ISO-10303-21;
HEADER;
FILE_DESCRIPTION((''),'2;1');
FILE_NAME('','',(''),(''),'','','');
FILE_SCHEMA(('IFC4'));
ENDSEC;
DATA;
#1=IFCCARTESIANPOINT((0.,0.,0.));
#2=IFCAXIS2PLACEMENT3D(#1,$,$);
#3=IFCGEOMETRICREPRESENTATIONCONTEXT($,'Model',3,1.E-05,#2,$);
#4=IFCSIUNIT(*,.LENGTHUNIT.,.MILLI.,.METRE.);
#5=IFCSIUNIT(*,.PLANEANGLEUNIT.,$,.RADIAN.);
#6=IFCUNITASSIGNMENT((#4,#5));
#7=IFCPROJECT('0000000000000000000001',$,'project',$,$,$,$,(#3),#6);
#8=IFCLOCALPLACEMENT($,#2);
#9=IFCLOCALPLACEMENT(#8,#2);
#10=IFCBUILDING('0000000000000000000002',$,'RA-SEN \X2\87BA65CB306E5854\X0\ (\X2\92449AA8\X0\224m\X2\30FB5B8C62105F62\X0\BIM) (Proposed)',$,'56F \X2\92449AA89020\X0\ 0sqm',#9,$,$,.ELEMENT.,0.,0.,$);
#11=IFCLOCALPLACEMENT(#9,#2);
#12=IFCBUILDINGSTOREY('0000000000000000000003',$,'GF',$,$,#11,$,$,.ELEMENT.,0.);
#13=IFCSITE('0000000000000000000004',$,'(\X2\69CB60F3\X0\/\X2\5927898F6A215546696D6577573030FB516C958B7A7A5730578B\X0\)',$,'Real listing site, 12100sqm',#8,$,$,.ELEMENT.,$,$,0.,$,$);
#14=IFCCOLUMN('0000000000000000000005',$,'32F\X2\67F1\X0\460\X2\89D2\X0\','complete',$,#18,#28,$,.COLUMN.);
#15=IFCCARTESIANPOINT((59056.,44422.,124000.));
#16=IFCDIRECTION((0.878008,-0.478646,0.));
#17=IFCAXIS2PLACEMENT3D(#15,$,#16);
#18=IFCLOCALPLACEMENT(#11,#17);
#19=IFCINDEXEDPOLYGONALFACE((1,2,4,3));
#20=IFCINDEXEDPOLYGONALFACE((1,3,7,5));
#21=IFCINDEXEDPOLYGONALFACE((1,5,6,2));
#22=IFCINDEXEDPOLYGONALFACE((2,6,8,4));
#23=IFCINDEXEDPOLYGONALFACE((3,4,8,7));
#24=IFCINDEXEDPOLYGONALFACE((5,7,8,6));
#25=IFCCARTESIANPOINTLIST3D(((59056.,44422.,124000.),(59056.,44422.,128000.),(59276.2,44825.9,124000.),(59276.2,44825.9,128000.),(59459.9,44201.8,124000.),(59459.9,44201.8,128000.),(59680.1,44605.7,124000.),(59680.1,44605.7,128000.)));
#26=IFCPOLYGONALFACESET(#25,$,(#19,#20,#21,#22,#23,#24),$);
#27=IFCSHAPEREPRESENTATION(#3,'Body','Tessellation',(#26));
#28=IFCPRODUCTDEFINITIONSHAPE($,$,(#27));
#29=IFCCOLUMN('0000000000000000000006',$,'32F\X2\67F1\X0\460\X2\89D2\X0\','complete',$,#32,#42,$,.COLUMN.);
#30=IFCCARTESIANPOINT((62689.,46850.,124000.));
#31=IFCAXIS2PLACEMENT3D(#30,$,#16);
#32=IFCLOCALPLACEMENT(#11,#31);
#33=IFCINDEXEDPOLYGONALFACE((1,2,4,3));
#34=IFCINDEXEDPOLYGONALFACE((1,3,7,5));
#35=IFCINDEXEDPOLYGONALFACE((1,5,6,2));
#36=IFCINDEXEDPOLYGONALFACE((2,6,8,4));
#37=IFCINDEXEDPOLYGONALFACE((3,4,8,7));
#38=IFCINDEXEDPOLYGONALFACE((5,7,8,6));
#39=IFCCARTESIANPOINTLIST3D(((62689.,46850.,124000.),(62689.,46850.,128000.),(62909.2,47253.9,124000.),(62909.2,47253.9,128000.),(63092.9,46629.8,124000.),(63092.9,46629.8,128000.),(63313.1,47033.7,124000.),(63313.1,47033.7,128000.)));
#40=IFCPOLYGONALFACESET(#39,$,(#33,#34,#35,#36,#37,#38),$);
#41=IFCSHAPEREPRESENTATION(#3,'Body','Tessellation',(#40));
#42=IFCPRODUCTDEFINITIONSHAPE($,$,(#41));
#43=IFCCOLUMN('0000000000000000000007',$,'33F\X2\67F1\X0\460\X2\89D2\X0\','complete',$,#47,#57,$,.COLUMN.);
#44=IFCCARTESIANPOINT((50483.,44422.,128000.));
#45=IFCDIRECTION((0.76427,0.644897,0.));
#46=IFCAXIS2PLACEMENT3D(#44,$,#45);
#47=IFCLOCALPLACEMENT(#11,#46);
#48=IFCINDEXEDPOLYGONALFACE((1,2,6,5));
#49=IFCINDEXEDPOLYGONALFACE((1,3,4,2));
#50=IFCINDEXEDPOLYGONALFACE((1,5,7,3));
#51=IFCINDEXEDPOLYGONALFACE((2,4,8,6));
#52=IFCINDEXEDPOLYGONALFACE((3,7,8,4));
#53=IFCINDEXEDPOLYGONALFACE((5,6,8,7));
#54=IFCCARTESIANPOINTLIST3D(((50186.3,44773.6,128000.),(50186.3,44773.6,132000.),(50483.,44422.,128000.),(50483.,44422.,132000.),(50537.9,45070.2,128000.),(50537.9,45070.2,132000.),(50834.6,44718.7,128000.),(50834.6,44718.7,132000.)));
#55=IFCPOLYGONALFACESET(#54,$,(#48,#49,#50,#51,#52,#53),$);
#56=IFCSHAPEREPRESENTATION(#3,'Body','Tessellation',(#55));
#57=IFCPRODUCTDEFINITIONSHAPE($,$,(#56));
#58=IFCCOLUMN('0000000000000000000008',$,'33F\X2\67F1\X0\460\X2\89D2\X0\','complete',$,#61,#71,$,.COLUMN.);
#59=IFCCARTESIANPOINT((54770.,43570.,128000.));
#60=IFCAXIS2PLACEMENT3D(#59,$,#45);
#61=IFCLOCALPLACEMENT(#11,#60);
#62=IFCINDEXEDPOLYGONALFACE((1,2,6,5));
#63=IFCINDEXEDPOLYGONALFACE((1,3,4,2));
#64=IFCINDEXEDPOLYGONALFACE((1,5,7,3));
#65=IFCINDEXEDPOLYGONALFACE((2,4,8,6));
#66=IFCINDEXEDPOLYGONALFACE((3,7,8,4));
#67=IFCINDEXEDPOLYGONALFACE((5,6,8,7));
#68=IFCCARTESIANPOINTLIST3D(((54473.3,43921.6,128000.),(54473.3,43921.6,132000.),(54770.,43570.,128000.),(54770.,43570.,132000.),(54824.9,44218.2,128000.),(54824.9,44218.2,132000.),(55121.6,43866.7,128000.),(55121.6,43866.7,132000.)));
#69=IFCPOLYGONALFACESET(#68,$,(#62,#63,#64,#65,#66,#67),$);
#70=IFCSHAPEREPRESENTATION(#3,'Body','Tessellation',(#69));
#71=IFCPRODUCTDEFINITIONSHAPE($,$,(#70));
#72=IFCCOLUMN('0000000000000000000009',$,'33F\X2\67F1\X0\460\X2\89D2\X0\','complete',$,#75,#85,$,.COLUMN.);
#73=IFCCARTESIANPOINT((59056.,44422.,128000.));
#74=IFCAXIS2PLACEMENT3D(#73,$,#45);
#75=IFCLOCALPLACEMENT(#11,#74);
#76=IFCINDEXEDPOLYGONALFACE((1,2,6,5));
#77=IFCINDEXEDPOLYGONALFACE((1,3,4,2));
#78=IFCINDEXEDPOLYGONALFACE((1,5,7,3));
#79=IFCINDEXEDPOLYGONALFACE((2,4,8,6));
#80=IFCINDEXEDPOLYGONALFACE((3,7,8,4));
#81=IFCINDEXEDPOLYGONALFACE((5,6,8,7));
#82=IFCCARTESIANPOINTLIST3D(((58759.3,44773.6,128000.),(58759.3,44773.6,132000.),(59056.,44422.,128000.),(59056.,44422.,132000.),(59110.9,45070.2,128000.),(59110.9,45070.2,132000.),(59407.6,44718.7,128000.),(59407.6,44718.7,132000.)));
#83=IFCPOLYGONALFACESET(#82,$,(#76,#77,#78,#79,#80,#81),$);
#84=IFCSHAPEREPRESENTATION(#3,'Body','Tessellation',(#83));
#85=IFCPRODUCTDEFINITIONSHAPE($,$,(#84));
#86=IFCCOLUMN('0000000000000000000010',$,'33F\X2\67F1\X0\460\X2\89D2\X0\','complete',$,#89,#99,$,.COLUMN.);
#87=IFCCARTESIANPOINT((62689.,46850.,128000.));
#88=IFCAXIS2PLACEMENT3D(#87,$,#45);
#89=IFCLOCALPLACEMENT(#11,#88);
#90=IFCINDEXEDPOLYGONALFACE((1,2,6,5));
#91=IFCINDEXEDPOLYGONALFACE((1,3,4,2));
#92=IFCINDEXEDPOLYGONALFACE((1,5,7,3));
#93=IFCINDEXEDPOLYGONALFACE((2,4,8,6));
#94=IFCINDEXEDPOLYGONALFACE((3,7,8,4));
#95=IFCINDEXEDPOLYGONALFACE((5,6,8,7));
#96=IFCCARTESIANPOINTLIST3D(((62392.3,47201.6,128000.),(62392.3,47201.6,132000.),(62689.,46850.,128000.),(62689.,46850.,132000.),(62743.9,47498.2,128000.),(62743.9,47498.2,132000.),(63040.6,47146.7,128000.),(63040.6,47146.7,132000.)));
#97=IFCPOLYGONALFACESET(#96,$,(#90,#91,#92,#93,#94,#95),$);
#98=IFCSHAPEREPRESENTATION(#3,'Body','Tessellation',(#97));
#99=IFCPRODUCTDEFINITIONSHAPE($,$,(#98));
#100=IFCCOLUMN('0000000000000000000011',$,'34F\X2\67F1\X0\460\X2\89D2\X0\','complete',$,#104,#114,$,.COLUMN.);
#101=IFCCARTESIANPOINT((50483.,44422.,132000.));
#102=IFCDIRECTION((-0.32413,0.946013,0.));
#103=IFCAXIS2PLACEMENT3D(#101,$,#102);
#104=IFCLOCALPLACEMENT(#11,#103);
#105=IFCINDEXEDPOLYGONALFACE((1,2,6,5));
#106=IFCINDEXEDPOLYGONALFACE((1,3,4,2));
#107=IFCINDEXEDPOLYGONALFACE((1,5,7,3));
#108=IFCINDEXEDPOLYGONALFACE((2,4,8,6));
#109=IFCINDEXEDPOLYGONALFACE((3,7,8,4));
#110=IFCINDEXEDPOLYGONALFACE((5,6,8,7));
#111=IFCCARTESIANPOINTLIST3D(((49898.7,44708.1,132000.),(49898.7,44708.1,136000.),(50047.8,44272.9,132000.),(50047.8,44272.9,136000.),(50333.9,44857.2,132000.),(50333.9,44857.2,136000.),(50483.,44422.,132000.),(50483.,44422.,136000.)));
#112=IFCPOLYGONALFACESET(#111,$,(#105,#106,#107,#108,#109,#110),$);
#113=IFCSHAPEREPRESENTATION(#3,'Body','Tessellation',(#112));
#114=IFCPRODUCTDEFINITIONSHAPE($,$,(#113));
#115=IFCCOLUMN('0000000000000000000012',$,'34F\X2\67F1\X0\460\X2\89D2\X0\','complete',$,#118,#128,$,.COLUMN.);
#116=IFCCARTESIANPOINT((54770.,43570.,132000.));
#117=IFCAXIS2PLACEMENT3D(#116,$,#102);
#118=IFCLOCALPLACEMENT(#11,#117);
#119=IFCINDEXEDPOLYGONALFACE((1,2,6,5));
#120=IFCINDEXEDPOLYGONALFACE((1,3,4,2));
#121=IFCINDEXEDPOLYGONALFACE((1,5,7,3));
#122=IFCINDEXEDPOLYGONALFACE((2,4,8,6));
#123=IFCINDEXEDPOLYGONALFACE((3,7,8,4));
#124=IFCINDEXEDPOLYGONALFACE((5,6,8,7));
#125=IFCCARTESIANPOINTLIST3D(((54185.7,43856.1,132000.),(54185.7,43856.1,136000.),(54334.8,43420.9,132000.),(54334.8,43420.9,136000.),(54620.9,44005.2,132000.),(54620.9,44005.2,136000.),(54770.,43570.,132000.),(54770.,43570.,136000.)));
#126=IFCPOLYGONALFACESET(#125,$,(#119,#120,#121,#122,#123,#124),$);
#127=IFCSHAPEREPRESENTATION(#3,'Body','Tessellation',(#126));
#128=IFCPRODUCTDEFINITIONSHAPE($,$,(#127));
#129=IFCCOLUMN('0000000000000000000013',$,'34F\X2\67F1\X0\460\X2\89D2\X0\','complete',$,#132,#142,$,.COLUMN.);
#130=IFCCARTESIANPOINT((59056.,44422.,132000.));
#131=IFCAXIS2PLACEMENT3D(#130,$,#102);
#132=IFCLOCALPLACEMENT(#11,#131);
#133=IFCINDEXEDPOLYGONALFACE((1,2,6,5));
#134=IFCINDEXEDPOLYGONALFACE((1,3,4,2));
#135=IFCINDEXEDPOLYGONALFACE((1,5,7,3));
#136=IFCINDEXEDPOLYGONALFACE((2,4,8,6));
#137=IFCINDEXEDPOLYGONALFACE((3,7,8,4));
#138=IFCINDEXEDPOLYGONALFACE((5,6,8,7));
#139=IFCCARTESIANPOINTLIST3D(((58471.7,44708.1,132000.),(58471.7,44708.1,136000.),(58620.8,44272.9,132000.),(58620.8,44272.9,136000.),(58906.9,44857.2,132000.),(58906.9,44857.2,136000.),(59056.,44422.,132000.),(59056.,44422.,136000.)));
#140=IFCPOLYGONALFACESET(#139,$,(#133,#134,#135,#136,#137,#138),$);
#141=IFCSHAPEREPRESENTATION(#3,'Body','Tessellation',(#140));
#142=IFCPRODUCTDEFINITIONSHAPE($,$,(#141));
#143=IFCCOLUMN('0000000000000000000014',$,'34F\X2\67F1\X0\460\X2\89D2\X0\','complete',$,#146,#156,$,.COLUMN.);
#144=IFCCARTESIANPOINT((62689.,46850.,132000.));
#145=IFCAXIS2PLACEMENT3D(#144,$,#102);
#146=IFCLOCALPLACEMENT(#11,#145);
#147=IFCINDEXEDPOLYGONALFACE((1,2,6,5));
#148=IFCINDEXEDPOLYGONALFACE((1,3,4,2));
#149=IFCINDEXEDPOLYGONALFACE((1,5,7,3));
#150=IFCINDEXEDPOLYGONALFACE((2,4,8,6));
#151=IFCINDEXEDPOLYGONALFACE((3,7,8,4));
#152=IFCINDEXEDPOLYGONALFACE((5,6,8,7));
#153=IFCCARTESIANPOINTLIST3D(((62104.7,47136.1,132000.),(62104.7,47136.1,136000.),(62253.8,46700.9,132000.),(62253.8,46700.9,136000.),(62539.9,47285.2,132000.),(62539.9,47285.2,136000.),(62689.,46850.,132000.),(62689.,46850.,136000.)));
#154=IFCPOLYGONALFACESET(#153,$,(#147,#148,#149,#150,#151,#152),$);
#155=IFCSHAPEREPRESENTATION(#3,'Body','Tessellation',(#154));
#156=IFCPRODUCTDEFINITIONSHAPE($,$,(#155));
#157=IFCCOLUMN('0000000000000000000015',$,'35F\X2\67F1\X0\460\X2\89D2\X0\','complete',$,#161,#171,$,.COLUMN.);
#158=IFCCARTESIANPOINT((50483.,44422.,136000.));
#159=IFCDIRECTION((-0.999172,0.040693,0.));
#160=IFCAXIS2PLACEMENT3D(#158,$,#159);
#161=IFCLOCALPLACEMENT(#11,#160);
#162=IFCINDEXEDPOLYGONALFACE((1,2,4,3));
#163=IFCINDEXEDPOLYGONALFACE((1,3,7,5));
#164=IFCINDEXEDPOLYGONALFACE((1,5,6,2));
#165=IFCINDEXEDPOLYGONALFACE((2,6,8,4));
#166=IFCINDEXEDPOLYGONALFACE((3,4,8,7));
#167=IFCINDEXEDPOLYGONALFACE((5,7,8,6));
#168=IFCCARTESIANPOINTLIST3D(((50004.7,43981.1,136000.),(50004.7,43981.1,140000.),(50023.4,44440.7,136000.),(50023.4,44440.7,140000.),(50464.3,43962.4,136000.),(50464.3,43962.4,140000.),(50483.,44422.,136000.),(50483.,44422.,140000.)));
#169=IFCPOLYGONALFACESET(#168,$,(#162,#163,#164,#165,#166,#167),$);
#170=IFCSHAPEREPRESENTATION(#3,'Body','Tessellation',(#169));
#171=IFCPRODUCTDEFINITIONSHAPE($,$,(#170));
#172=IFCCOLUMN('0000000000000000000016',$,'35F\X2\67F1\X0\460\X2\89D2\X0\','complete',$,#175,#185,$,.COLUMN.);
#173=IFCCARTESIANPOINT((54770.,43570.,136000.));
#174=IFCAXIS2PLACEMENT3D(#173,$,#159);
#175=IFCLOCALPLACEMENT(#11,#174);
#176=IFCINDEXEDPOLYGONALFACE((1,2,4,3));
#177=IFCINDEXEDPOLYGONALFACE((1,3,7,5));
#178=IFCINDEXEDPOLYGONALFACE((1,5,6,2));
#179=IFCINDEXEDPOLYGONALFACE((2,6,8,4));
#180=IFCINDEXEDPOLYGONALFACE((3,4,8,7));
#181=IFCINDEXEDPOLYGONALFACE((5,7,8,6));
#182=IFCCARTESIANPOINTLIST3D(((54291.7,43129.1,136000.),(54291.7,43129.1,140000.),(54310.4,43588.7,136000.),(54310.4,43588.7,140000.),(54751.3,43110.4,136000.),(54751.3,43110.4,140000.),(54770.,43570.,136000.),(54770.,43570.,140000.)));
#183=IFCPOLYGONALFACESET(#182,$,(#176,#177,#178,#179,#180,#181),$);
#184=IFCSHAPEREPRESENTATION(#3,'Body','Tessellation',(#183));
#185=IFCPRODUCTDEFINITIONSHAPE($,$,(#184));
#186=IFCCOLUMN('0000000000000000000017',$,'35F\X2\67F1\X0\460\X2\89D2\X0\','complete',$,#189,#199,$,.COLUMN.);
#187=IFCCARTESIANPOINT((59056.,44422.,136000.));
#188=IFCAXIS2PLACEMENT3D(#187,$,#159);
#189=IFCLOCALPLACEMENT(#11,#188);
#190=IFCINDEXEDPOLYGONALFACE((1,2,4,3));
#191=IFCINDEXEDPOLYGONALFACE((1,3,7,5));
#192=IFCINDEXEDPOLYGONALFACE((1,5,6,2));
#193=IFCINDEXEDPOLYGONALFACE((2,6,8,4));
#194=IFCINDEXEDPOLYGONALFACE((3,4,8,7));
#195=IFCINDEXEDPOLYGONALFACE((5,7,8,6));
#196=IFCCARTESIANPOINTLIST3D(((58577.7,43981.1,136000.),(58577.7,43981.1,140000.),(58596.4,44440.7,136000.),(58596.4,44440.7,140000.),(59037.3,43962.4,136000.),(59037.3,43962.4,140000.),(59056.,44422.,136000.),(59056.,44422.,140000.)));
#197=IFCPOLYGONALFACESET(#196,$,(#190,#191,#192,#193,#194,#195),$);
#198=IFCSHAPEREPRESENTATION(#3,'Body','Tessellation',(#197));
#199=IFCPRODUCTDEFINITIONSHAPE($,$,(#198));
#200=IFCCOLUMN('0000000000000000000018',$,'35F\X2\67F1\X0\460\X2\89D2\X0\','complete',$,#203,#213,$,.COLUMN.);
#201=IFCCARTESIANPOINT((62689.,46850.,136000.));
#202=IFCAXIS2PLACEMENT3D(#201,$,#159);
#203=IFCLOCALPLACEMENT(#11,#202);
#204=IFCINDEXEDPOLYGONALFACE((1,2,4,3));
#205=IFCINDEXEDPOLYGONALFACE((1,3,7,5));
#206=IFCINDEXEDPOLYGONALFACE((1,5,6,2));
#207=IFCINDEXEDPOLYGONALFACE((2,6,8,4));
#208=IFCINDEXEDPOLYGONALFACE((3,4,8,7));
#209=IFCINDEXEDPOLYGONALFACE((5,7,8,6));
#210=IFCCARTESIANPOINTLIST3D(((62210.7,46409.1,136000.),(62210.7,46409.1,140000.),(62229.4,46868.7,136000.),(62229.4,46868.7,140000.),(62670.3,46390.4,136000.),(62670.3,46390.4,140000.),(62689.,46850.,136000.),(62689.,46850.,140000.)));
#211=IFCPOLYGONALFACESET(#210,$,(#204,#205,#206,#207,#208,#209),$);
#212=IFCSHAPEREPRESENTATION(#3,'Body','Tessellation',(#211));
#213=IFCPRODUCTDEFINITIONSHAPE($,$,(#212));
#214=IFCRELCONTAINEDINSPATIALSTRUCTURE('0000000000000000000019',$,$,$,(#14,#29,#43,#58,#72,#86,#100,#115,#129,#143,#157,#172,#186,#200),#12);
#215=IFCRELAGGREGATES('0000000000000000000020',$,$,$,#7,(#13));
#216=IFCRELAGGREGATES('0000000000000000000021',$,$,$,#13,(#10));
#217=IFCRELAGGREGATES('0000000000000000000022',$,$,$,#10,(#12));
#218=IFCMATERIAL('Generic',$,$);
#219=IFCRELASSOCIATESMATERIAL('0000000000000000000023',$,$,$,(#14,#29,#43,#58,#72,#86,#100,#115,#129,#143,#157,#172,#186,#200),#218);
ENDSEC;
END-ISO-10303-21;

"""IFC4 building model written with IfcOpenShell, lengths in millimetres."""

from ifc_helpers import new_model, si_unit, frame, frame_2d, origin, place, context, project, spatial, rectangle, extrude, material, element, save


model = new_model("IFC4")

# Units and contexts
model_context = context("Model", 3, precision=1e-05, world=origin())
ifc_project = project(units=[si_unit("LENGTHUNIT", "METRE", prefix="MILLI"), si_unit("PLANEANGLEUNIT", "RADIAN")], contexts=[model_context])

# Site, building, storey
site_placement = place(None, origin())
site = spatial("IfcSite", under=ifc_project, at=site_placement, Name="(構想/大規模商業敷地・公開空地型)", ObjectType="Real listing site, 12100sqm", CompositionType="ELEMENT", RefElevation=0.0)
building_placement = place(site_placement, origin())
building = spatial("IfcBuilding", under=site, at=building_placement, Name="RA-SEN 螺旋の塔 (鉄骨224m・完成形BIM) (Proposed)", ObjectType="56F 鉄骨造 0sqm", CompositionType="ELEMENT", ElevationOfRefHeight=0.0, ElevationOfTerrain=0.0)
storey_placement = place(building_placement, origin())
storey = spatial("IfcBuildingStorey", under=building, at=storey_placement, Name="GF", CompositionType="ELEMENT", Elevation=0.0)

# Columns
ifc_material = material(Name="Generic")
column_1_placement = place(storey_placement, frame((59056.0, 44422.0, 124000.0), x_axis=(0.878008, -0.478646, 0.0)))
element("IfcColumn", 1, at=column_1_placement, inside=storey, material=ifc_material, Name="32F柱460角", Description="complete", PredefinedType="COLUMN", context=model_context, shape_type="SweptSolid", body=[
    extrude(rectangle(XDim=460.0, YDim=460.0, at=frame_2d((230.0, 230.0))), frame((59056.0, 44422.0, 124000.0), x_axis=(0.878008, -0.478646, 0.0)), (0.0, 0.0, 1.0), 4000.0),
])
column_2_placement = place(storey_placement, frame((62689.0, 46850.0, 124000.0), x_axis=(0.878008, -0.478646, 0.0)))
element("IfcColumn", 2, at=column_2_placement, inside=storey, material=ifc_material, Name="32F柱460角", Description="complete", PredefinedType="COLUMN", context=model_context, shape_type="SweptSolid", body=[
    extrude(rectangle(XDim=460.0, YDim=460.0, at=frame_2d((230.0, 230.0))), frame((62689.0, 46850.0, 124000.0), x_axis=(0.878008, -0.478646, 0.0)), (0.0, 0.0, 1.0), 4000.0),
])
column_3_placement = place(storey_placement, frame((50483.0, 44422.0, 128000.0), x_axis=(0.76427, 0.644897, 0.0)))
element("IfcColumn", 3, at=column_3_placement, inside=storey, material=ifc_material, Name="33F柱460角", Description="complete", PredefinedType="COLUMN", context=model_context, shape_type="SweptSolid", body=[
    extrude(rectangle(XDim=460.0, YDim=460.0, at=frame_2d((230.0, 230.0))), frame((50483.0, 44422.0, 128000.0), x_axis=(0.76427, 0.644897, 0.0)), (0.0, 0.0, 1.0), 4000.0),
])
column_4_placement = place(storey_placement, frame((54770.0, 43570.0, 128000.0), x_axis=(0.76427, 0.644897, 0.0)))
element("IfcColumn", 4, at=column_4_placement, inside=storey, material=ifc_material, Name="33F柱460角", Description="complete", PredefinedType="COLUMN", context=model_context, shape_type="SweptSolid", body=[
    extrude(rectangle(XDim=460.0, YDim=460.0, at=frame_2d((230.0, 230.0))), frame((54770.0, 43570.0, 128000.0), x_axis=(0.76427, 0.644897, 0.0)), (0.0, 0.0, 1.0), 4000.0),
])
column_5_placement = place(storey_placement, frame((59056.0, 44422.0, 128000.0), x_axis=(0.76427, 0.644897, 0.0)))
element("IfcColumn", 5, at=column_5_placement, inside=storey, material=ifc_material, Name="33F柱460角", Description="complete", PredefinedType="COLUMN", context=model_context, shape_type="SweptSolid", body=[
    extrude(rectangle(XDim=460.0, YDim=460.0, at=frame_2d((230.0, 230.0))), frame((59056.0, 44422.0, 128000.0), x_axis=(0.76427, 0.644897, 0.0)), (0.0, 0.0, 1.0), 4000.0),
])
column_6_placement = place(storey_placement, frame((62689.0, 46850.0, 128000.0), x_axis=(0.76427, 0.644897, 0.0)))
element("IfcColumn", 6, at=column_6_placement, inside=storey, material=ifc_material, Name="33F柱460角", Description="complete", PredefinedType="COLUMN", context=model_context, shape_type="SweptSolid", body=[
    extrude(rectangle(XDim=460.0, YDim=460.0, at=frame_2d((230.0, 230.0))), frame((62689.0, 46850.0, 128000.0), x_axis=(0.76427, 0.644897, 0.0)), (0.0, 0.0, 1.0), 4000.0),
])
column_7_placement = place(storey_placement, frame((50483.0, 44422.0, 132000.0), x_axis=(-0.32413, 0.946013, 0.0)))
element("IfcColumn", 7, at=column_7_placement, inside=storey, material=ifc_material, Name="34F柱460角", Description="complete", PredefinedType="COLUMN", context=model_context, shape_type="SweptSolid", body=[
    extrude(rectangle(XDim=460.0, YDim=460.0, at=frame_2d((230.0, 230.0))), frame((50483.0, 44422.0, 132000.0), x_axis=(-0.32413, 0.946013, 0.0)), (0.0, 0.0, 1.0), 4000.0),
])
column_8_placement = place(storey_placement, frame((54770.0, 43570.0, 132000.0), x_axis=(-0.32413, 0.946013, 0.0)))
element("IfcColumn", 8, at=column_8_placement, inside=storey, material=ifc_material, Name="34F柱460角", Description="complete", PredefinedType="COLUMN", context=model_context, shape_type="SweptSolid", body=[
    extrude(rectangle(XDim=460.0, YDim=460.0, at=frame_2d((230.0, 230.0))), frame((54770.0, 43570.0, 132000.0), x_axis=(-0.32413, 0.946013, 0.0)), (0.0, 0.0, 1.0), 4000.0),
])
column_9_placement = place(storey_placement, frame((59056.0, 44422.0, 132000.0), x_axis=(-0.32413, 0.946013, 0.0)))
element("IfcColumn", 9, at=column_9_placement, inside=storey, material=ifc_material, Name="34F柱460角", Description="complete", PredefinedType="COLUMN", context=model_context, shape_type="SweptSolid", body=[
    extrude(rectangle(XDim=460.0, YDim=460.0, at=frame_2d((230.0, 230.0))), frame((59056.0, 44422.0, 132000.0), x_axis=(-0.32413, 0.946013, 0.0)), (0.0, 0.0, 1.0), 4000.0),
])
column_10_placement = place(storey_placement, frame((62689.0, 46850.0, 132000.0), x_axis=(-0.32413, 0.946013, 0.0)))
element("IfcColumn", 10, at=column_10_placement, inside=storey, material=ifc_material, Name="34F柱460角", Description="complete", PredefinedType="COLUMN", context=model_context, shape_type="SweptSolid", body=[
    extrude(rectangle(XDim=460.0, YDim=460.0, at=frame_2d((230.0, 230.0))), frame((62689.0, 46850.0, 132000.0), x_axis=(-0.32413, 0.946013, 0.0)), (0.0, 0.0, 1.0), 4000.0),
])
column_11_placement = place(storey_placement, frame((50483.0, 44422.0, 136000.0), x_axis=(-0.999172, 0.040693, 0.0)))
element("IfcColumn", 11, at=column_11_placement, inside=storey, material=ifc_material, Name="35F柱460角", Description="complete", PredefinedType="COLUMN", context=model_context, shape_type="SweptSolid", body=[
    extrude(rectangle(XDim=460.0, YDim=460.0, at=frame_2d((230.0, 230.0))), frame((50483.0, 44422.0, 136000.0), x_axis=(-0.999172, 0.040693, 0.0)), (0.0, 0.0, 1.0), 4000.0),
])
column_12_placement = place(storey_placement, frame((54770.0, 43570.0, 136000.0), x_axis=(-0.999172, 0.040693, 0.0)))
element("IfcColumn", 12, at=column_12_placement, inside=storey, material=ifc_material, Name="35F柱460角", Description="complete", PredefinedType="COLUMN", context=model_context, shape_type="SweptSolid", body=[
    extrude(rectangle(XDim=460.0, YDim=460.0, at=frame_2d((230.0, 230.0))), frame((54770.0, 43570.0, 136000.0), x_axis=(-0.999172, 0.040693, 0.0)), (0.0, 0.0, 1.0), 4000.0),
])
column_13_placement = place(storey_placement, frame((59056.0, 44422.0, 136000.0), x_axis=(-0.999172, 0.040693, 0.0)))
element("IfcColumn", 13, at=column_13_placement, inside=storey, material=ifc_material, Name="35F柱460角", Description="complete", PredefinedType="COLUMN", context=model_context, shape_type="SweptSolid", body=[
    extrude(rectangle(XDim=460.0, YDim=460.0, at=frame_2d((230.0, 230.0))), frame((59056.0, 44422.0, 136000.0), x_axis=(-0.999172, 0.040693, 0.0)), (0.0, 0.0, 1.0), 4000.0),
])
column_14_placement = place(storey_placement, frame((62689.0, 46850.0, 136000.0), x_axis=(-0.999172, 0.040693, 0.0)))
element("IfcColumn", 14, at=column_14_placement, inside=storey, material=ifc_material, Name="35F柱460角", Description="complete", PredefinedType="COLUMN", context=model_context, shape_type="SweptSolid", body=[
    extrude(rectangle(XDim=460.0, YDim=460.0, at=frame_2d((230.0, 230.0))), frame((62689.0, 46850.0, 136000.0), x_axis=(-0.999172, 0.040693, 0.0)), (0.0, 0.0, 1.0), 4000.0),
])

save(model, "model.ifc")
